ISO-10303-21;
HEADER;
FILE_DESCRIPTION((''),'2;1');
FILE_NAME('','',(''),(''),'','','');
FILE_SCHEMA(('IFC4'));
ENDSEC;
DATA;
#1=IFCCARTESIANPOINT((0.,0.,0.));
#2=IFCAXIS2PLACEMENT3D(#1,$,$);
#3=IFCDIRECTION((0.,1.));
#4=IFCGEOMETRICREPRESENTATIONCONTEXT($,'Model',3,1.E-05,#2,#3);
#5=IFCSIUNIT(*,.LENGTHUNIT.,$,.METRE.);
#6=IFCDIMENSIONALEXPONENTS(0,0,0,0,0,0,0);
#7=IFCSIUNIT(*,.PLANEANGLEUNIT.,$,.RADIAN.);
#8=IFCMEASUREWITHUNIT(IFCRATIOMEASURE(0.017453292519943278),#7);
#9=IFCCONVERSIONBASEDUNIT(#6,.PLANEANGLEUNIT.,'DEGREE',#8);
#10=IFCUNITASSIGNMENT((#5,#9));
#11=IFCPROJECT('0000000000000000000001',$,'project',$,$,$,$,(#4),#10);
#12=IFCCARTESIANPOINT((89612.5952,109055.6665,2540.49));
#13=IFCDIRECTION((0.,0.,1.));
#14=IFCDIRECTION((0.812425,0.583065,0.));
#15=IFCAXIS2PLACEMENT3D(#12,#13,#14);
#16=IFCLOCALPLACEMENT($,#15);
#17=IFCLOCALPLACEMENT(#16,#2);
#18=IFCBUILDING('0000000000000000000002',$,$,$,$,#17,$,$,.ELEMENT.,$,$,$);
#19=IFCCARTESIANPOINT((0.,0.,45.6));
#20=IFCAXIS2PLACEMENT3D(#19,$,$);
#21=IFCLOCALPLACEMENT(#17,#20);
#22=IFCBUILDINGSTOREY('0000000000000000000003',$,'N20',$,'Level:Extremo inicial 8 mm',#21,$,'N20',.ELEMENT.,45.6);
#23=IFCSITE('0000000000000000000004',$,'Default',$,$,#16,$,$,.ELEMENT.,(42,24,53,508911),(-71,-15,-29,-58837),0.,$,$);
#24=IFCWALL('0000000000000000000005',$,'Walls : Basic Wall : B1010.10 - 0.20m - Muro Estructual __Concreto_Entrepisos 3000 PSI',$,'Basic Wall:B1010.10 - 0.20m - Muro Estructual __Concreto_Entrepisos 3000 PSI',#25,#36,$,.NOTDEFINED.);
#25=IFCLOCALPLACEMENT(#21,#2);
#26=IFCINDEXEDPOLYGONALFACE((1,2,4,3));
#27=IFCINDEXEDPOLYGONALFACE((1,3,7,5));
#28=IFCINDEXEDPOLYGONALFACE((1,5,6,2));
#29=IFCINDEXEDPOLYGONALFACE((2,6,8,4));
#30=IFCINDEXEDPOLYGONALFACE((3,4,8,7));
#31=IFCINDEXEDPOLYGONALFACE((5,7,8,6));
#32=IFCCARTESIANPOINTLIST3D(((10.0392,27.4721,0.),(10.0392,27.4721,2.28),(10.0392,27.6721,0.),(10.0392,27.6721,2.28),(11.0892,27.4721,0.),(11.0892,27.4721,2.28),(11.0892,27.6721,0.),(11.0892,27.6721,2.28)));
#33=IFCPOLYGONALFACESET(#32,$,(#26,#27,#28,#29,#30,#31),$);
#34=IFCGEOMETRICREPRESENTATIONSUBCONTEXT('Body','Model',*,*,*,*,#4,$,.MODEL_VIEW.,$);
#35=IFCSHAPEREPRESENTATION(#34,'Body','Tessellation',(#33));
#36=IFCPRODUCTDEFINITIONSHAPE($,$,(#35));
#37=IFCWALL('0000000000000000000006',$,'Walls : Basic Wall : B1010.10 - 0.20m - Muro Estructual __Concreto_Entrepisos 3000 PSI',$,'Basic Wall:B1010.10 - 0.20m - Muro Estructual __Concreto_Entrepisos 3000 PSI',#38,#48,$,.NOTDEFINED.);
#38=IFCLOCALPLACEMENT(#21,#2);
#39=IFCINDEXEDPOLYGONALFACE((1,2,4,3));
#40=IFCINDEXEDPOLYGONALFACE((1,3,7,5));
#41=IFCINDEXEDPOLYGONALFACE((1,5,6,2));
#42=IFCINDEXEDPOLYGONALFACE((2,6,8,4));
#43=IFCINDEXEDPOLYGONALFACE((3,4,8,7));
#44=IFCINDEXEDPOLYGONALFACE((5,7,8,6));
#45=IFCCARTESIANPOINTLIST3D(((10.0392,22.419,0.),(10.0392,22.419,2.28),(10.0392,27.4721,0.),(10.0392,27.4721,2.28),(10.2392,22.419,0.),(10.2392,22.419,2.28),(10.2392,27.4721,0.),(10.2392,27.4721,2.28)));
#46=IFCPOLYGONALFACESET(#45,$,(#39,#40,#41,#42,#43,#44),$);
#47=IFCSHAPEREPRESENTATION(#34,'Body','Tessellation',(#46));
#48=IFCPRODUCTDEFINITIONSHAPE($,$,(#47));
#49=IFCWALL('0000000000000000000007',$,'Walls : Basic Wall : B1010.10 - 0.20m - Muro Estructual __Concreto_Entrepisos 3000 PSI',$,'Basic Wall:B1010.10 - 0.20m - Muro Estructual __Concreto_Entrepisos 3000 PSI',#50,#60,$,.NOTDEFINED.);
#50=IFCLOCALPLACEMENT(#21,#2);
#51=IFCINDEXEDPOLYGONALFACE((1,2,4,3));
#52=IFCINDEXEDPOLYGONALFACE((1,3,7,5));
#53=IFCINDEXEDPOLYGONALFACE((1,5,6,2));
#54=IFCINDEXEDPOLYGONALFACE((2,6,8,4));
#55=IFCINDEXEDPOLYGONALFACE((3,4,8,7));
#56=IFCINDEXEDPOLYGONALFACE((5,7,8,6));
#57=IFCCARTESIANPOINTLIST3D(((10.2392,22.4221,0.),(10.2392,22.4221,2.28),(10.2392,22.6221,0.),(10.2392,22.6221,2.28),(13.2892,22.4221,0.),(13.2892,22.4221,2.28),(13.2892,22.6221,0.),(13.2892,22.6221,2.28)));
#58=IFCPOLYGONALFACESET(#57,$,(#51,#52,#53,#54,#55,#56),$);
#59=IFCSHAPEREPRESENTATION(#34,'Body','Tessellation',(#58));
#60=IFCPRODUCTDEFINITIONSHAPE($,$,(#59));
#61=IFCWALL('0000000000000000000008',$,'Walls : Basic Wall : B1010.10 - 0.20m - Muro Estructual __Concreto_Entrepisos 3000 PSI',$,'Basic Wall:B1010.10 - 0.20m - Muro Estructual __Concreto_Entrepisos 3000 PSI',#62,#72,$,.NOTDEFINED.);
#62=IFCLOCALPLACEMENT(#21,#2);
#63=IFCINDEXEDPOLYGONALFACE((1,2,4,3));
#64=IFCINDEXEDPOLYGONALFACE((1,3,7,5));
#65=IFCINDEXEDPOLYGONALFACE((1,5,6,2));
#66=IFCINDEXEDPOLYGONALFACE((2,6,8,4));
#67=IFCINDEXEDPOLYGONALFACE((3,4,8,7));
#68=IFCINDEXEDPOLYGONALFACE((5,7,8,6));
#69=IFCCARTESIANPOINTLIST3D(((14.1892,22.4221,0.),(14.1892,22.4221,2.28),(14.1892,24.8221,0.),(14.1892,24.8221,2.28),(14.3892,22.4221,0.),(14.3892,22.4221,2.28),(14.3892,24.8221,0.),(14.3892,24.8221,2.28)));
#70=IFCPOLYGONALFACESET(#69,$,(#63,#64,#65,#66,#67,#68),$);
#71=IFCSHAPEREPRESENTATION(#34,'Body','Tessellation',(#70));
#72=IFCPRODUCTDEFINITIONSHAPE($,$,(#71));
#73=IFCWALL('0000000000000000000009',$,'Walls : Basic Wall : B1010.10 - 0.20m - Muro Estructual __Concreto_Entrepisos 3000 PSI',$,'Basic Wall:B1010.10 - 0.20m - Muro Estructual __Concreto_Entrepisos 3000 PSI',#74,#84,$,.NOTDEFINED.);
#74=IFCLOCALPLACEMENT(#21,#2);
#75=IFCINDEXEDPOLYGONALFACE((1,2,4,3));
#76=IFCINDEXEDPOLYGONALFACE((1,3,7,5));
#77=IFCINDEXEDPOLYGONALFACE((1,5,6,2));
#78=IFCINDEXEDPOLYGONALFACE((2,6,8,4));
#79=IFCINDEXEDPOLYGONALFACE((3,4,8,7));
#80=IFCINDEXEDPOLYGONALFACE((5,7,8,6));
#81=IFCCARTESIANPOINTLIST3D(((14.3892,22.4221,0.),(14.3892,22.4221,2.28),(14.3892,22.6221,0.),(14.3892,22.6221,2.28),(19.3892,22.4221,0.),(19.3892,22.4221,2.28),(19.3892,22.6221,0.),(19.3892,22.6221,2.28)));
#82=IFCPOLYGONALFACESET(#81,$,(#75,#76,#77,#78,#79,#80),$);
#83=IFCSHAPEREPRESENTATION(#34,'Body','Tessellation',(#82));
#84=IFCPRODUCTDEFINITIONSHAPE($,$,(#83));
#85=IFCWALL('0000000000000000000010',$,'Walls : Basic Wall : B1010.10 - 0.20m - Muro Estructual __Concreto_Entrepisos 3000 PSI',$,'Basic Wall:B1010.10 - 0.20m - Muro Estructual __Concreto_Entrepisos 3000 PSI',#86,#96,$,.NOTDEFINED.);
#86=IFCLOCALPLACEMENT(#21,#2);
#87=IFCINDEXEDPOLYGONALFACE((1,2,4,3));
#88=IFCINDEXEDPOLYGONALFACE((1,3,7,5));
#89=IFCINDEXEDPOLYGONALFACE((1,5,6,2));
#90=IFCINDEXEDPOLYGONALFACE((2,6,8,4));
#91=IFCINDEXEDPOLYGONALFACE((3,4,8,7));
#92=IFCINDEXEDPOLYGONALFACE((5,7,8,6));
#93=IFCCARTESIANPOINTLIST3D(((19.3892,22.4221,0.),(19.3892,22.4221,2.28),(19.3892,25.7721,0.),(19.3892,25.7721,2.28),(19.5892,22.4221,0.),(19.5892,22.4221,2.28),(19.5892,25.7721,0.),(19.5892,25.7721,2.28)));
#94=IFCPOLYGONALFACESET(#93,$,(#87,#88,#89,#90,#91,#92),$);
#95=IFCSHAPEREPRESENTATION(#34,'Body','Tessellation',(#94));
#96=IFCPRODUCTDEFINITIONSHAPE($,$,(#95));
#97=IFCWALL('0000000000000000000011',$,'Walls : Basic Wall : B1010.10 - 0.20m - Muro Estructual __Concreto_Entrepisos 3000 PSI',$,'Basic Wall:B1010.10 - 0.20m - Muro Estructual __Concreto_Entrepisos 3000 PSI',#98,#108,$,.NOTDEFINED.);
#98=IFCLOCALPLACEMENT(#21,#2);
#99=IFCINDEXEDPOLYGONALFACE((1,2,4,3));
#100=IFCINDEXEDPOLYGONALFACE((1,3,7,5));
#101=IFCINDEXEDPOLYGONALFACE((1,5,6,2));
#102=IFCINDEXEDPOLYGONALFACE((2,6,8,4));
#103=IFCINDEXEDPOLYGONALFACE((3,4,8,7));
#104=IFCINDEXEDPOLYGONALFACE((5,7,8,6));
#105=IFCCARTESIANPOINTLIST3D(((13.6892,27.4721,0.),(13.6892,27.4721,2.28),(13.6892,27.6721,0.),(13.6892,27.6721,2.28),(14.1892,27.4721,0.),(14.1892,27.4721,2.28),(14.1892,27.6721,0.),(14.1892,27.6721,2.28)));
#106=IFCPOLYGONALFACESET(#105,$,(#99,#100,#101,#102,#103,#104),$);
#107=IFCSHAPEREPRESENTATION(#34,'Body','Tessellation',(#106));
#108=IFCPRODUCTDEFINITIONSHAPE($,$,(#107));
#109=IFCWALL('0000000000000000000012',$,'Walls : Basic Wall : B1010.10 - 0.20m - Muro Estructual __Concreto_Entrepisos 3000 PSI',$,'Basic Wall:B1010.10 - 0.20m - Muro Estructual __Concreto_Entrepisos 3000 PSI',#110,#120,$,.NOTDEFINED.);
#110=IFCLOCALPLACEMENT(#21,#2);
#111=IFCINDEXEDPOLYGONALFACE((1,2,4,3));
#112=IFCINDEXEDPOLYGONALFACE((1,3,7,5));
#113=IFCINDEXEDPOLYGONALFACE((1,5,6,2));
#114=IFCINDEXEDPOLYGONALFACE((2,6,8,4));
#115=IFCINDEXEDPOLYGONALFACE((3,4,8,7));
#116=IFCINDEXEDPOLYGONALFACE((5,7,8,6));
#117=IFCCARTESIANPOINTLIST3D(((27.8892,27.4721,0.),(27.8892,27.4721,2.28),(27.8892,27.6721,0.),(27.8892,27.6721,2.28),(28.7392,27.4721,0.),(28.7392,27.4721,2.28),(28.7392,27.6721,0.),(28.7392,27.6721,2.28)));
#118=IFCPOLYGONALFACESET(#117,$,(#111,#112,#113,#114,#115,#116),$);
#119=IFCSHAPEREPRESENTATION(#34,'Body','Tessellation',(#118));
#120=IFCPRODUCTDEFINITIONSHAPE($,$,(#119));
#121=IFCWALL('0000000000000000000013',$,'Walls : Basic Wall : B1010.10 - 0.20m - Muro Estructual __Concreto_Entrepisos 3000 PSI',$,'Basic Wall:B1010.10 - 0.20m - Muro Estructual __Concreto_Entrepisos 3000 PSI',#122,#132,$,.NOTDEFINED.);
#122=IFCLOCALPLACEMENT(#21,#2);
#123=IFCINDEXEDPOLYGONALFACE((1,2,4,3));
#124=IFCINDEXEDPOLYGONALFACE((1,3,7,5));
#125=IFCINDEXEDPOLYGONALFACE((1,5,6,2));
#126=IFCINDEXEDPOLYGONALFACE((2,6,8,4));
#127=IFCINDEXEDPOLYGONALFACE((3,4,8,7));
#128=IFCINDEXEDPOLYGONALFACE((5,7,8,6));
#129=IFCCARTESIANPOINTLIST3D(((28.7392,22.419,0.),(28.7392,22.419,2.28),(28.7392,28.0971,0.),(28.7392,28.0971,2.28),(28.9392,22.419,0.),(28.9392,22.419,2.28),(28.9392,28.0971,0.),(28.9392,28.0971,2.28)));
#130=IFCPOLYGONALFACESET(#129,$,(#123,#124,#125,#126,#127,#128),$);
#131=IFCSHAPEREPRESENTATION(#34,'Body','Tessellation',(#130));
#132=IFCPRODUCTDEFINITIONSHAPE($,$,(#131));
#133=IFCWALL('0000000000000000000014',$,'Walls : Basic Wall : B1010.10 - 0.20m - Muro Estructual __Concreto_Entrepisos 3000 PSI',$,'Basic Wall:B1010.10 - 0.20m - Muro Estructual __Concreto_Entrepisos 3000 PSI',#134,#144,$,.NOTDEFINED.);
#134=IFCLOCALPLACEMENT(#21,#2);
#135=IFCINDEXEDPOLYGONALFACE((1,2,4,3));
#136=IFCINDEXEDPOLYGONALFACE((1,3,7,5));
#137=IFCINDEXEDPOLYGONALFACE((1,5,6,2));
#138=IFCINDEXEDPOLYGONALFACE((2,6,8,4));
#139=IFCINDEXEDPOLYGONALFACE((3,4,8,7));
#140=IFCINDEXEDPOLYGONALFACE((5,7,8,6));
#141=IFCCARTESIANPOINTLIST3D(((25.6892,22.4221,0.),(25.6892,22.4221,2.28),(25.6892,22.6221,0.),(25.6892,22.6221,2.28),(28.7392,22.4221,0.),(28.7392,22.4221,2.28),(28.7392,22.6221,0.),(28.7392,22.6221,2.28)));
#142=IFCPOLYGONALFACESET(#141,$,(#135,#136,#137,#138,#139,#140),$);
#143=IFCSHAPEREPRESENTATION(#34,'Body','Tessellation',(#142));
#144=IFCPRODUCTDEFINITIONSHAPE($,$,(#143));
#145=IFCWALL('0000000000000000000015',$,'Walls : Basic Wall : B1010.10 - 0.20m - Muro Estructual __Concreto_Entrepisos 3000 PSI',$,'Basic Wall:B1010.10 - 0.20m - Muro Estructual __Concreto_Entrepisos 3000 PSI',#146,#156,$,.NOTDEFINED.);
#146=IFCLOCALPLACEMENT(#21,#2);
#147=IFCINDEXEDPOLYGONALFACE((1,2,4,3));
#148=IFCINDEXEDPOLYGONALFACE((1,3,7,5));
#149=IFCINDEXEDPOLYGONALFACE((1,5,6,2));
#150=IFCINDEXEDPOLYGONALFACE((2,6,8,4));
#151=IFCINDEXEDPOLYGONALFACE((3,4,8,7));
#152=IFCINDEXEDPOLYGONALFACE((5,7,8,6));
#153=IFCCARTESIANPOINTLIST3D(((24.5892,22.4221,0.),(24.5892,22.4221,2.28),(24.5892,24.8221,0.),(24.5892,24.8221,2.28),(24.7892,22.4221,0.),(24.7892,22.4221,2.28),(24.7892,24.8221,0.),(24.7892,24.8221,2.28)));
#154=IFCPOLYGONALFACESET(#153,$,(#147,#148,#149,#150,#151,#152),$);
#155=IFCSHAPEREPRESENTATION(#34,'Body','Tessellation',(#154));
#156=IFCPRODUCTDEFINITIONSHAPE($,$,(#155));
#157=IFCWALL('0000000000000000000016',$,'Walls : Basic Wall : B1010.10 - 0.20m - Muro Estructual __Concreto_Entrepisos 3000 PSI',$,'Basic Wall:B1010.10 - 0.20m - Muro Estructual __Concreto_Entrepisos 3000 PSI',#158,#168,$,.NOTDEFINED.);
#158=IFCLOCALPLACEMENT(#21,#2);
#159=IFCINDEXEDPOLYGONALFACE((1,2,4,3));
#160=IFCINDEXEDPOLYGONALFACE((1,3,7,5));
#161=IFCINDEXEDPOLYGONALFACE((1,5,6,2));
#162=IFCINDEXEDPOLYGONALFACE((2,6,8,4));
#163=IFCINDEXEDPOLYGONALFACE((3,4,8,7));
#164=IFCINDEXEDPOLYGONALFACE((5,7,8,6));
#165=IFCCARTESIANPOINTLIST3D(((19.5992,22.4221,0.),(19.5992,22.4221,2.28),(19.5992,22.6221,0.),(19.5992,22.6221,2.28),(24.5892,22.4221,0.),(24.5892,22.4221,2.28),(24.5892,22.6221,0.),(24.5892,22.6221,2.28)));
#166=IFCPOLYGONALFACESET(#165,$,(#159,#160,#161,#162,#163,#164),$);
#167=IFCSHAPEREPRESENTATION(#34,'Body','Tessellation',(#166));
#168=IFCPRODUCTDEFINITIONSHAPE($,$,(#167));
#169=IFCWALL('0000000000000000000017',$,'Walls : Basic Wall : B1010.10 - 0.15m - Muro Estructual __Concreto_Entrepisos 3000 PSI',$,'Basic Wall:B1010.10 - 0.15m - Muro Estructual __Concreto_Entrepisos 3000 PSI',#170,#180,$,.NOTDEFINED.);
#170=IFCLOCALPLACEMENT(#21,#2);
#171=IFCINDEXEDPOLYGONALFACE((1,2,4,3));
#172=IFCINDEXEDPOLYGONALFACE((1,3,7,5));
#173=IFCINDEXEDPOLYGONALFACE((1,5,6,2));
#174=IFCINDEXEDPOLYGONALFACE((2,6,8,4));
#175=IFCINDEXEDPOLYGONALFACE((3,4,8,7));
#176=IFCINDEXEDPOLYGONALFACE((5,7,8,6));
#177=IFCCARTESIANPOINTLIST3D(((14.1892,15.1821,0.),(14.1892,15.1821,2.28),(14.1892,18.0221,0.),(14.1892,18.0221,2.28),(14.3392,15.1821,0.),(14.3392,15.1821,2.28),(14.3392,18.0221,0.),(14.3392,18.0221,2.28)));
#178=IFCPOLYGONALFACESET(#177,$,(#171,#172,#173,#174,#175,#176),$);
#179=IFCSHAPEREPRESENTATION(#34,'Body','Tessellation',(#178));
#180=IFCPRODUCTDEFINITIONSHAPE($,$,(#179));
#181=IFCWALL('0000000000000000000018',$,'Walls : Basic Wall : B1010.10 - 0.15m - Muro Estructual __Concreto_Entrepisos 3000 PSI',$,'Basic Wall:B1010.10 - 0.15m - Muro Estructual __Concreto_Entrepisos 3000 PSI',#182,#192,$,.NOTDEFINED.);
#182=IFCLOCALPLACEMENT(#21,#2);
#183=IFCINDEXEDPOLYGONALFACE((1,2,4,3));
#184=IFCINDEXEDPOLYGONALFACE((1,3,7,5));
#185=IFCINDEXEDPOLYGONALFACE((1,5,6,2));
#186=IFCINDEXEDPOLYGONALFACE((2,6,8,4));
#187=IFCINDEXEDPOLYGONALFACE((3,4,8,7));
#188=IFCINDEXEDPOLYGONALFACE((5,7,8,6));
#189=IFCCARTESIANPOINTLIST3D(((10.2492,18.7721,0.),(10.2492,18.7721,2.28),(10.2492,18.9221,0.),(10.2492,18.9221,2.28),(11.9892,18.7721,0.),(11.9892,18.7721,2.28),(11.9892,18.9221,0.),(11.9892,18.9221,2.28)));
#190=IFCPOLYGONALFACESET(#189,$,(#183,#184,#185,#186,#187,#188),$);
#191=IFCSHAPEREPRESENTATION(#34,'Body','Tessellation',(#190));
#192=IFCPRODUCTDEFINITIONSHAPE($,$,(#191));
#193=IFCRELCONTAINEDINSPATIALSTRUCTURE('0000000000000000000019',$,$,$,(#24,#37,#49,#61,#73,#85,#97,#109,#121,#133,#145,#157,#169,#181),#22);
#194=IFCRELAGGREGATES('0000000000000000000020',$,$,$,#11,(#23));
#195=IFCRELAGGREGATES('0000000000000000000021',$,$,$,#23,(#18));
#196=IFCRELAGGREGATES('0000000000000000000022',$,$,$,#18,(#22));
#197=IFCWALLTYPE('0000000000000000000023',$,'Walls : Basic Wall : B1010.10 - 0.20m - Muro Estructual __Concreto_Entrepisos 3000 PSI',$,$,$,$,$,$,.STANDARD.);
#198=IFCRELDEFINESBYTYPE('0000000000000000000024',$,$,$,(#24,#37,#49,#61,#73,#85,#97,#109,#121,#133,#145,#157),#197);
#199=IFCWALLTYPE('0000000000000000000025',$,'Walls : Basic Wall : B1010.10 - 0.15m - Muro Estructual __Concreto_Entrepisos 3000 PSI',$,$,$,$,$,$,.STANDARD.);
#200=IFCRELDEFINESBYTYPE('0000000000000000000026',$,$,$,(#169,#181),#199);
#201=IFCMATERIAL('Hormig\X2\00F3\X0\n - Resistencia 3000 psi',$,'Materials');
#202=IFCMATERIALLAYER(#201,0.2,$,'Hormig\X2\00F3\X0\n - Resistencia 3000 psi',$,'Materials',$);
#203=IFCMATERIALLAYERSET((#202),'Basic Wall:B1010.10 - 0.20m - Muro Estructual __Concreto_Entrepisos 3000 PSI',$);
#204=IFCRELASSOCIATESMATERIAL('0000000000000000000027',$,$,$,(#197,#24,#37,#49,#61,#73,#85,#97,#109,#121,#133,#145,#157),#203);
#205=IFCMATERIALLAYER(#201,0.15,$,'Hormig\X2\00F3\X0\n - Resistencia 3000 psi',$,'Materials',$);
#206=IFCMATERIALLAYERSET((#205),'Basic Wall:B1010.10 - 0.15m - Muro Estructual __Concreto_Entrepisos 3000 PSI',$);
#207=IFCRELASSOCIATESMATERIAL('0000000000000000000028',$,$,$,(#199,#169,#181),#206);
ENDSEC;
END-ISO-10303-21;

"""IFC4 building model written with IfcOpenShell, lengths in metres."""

from ifc_helpers import new_model, entity, si_unit, converted_unit, direction, frame, frame_2d, origin, place, context, subcontext, project, spatial, rectangle, extrude, material, layer, layer_set, layer_usage, type_object, element, save


model = new_model("IFC4")

# Units and contexts
model_context = context("Model", 3, precision=1e-05, world=origin(), true_north=direction((0.0, 1.0)))
body_context = subcontext(model_context, "Body", "Model", "MODEL_VIEW")
ifc_project = project(units=[si_unit("LENGTHUNIT", "METRE"), converted_unit("PLANEANGLEUNIT", "DEGREE", entity("IfcRatioMeasure", 0.017453292519943278), si_unit("PLANEANGLEUNIT", "RADIAN"), dimensions=[0, 0, 0, 0, 0, 0, 0])], contexts=[model_context])

# Site, building, storey
site_placement = place(None, frame((89612.5952, 109055.6665, 2540.49), z_axis=(0.0, 0.0, 1.0), x_axis=(0.812425, 0.583065, 0.0)))
site = spatial("IfcSite", under=ifc_project, at=site_placement, Name="Default", CompositionType="ELEMENT", RefLatitude=(42, 24, 53, 508911), RefLongitude=(-71, -15, -29, -58837), RefElevation=0.0)
building_placement = place(site_placement, origin())
building = spatial("IfcBuilding", under=site, at=building_placement, CompositionType="ELEMENT")
storey_placement = place(building_placement, frame((0.0, 0.0, 45.6)))
storey = spatial("IfcBuildingStorey", under=building, at=storey_placement, Name="N20", ObjectType="Level:Extremo inicial 8 mm", LongName="N20", CompositionType="ELEMENT", Elevation=45.6)

# Walls
ifc_material = material(Name="Hormigón - Resistencia 3000 psi", Category="Materials")
ifc_layer_1 = layer(ifc_material, 0.2, Name="Hormigón - Resistencia 3000 psi", Category="Materials")
ifc_layer_set_1 = layer_set([ifc_layer_1], Name="Basic Wall:B1010.10 - 0.20m - Muro Estructual __Concreto_Entrepisos 3000 PSI")
ifc_layer_usage_1 = layer_usage(ifc_layer_set_1, "AXIS2", "POSITIVE", -0.1)
wall_type_1 = type_object("IfcWallType", Name="Walls : Basic Wall : B1010.10 - 0.20m - Muro Estructual __Concreto_Entrepisos 3000 PSI", PredefinedType="STANDARD", material=ifc_layer_set_1)
wall_1_placement = place(storey_placement, frame((11.0892, 27.5721, 0.0), z_axis=(0.0, 0.0, 1.0), x_axis=(-1.0, 0.0, 0.0)))
element("IfcWall", 1, at=wall_1_placement, inside=storey, type_object=wall_type_1, material=ifc_layer_usage_1, Name="Walls : Basic Wall : B1010.10 - 0.20m - Muro Estructual __Concreto_Entrepisos 3000 PSI", ObjectType="Basic Wall:B1010.10 - 0.20m - Muro Estructual __Concreto_Entrepisos 3000 PSI", PredefinedType="NOTDEFINED", context=body_context, shape_type="SweptSolid", body=[
    extrude(rectangle(XDim=1.05, YDim=0.2, at=frame_2d((0.525, 0.0), x_axis=(-1.0, 0.0))), origin(), (0.0, 0.0, 1.0), 2.28),
])
ifc_layer_usage_2 = layer_usage(ifc_layer_set_1, "AXIS2", "POSITIVE", -0.1)
wall_2_placement = place(storey_placement, frame((10.1392, 27.4721, 0.0), z_axis=(0.0, 0.0, 1.0), x_axis=(0.0, -1.0, 0.0)))
element("IfcWall", 2, at=wall_2_placement, inside=storey, type_object=wall_type_1, material=ifc_layer_usage_2, Name="Walls : Basic Wall : B1010.10 - 0.20m - Muro Estructual __Concreto_Entrepisos 3000 PSI", ObjectType="Basic Wall:B1010.10 - 0.20m - Muro Estructual __Concreto_Entrepisos 3000 PSI", PredefinedType="NOTDEFINED", context=body_context, shape_type="SweptSolid", body=[
    extrude(rectangle(XDim=5.0531, YDim=0.2, at=frame_2d((2.5265, 0.0), x_axis=(-1.0, 0.0))), origin(), (0.0, 0.0, 1.0), 2.28),
])
ifc_layer_usage_3 = layer_usage(ifc_layer_set_1, "AXIS2", "POSITIVE", -0.1)
wall_3_placement = place(storey_placement, frame((10.2392, 22.5221, 0.0)))
element("IfcWall", 3, at=wall_3_placement, inside=storey, type_object=wall_type_1, material=ifc_layer_usage_3, Name="Walls : Basic Wall : B1010.10 - 0.20m - Muro Estructual __Concreto_Entrepisos 3000 PSI", ObjectType="Basic Wall:B1010.10 - 0.20m - Muro Estructual __Concreto_Entrepisos 3000 PSI", PredefinedType="NOTDEFINED", context=body_context, shape_type="SweptSolid", body=[
    extrude(rectangle(XDim=3.05, YDim=0.2, at=frame_2d((1.525, 0.0), x_axis=(-1.0, 0.0))), origin(), (0.0, 0.0, 1.0), 2.28),
])
ifc_layer_usage_4 = layer_usage(ifc_layer_set_1, "AXIS2", "POSITIVE", -0.1)
wall_4_placement = place(storey_placement, frame((14.2892, 24.8221, 0.0), z_axis=(0.0, 0.0, 1.0), x_axis=(0.0, -1.0, 0.0)))
element("IfcWall", 4, at=wall_4_placement, inside=storey, type_object=wall_type_1, material=ifc_layer_usage_4, Name="Walls : Basic Wall : B1010.10 - 0.20m - Muro Estructual __Concreto_Entrepisos 3000 PSI", ObjectType="Basic Wall:B1010.10 - 0.20m - Muro Estructual __Concreto_Entrepisos 3000 PSI", PredefinedType="NOTDEFINED", context=body_context, shape_type="SweptSolid", body=[
    extrude(rectangle(XDim=2.4, YDim=0.2, at=frame_2d((1.2, 0.0), x_axis=(-1.0, 0.0))), origin(), (0.0, 0.0, 1.0), 2.28),
])
ifc_layer_usage_5 = layer_usage(ifc_layer_set_1, "AXIS2", "POSITIVE", -0.1)
wall_5_placement = place(storey_placement, frame((14.3892, 22.5221, 0.0)))
element("IfcWall", 5, at=wall_5_placement, inside=storey, type_object=wall_type_1, material=ifc_layer_usage_5, Name="Walls : Basic Wall : B1010.10 - 0.20m - Muro Estructual __Concreto_Entrepisos 3000 PSI", ObjectType="Basic Wall:B1010.10 - 0.20m - Muro Estructual __Concreto_Entrepisos 3000 PSI", PredefinedType="NOTDEFINED", context=body_context, shape_type="SweptSolid", body=[
    extrude(rectangle(XDim=5.0, YDim=0.2, at=frame_2d((2.5, 0.0), x_axis=(-1.0, 0.0))), origin(), (0.0, 0.0, 1.0), 2.28),
])
ifc_layer_usage_6 = layer_usage(ifc_layer_set_1, "AXIS2", "POSITIVE", -0.1)
wall_6_placement = place(storey_placement, frame((19.4892, 22.4221, 0.0), z_axis=(0.0, 0.0, 1.0), x_axis=(0.0, 1.0, 0.0)))
element("IfcWall", 6, at=wall_6_placement, inside=storey, type_object=wall_type_1, material=ifc_layer_usage_6, Name="Walls : Basic Wall : B1010.10 - 0.20m - Muro Estructual __Concreto_Entrepisos 3000 PSI", ObjectType="Basic Wall:B1010.10 - 0.20m - Muro Estructual __Concreto_Entrepisos 3000 PSI", PredefinedType="NOTDEFINED", context=body_context, shape_type="SweptSolid", body=[
    extrude(rectangle(XDim=3.35, YDim=0.2, at=frame_2d((1.675, 0.0), x_axis=(-1.0, 0.0))), origin(), (0.0, 0.0, 1.0), 2.28),
])
ifc_layer_usage_7 = layer_usage(ifc_layer_set_1, "AXIS2", "POSITIVE", -0.1)
wall_7_placement = place(storey_placement, frame((13.6892, 27.5721, 0.0)))
element("IfcWall", 7, at=wall_7_placement, inside=storey, type_object=wall_type_1, material=ifc_layer_usage_7, Name="Walls : Basic Wall : B1010.10 - 0.20m - Muro Estructual __Concreto_Entrepisos 3000 PSI", ObjectType="Basic Wall:B1010.10 - 0.20m - Muro Estructual __Concreto_Entrepisos 3000 PSI", PredefinedType="NOTDEFINED", context=body_context, shape_type="SweptSolid", body=[
    extrude(rectangle(XDim=0.5, YDim=0.2, at=frame_2d((0.25, 0.0), x_axis=(-1.0, 0.0))), origin(), (0.0, 0.0, 1.0), 2.28),
])
ifc_layer_usage_8 = layer_usage(ifc_layer_set_1, "AXIS2", "NEGATIVE", 0.1)
wall_8_placement = place(storey_placement, frame((27.8892, 27.5721, 0.0)))
element("IfcWall", 8, at=wall_8_placement, inside=storey, type_object=wall_type_1, material=ifc_layer_usage_8, Name="Walls : Basic Wall : B1010.10 - 0.20m - Muro Estructual __Concreto_Entrepisos 3000 PSI", ObjectType="Basic Wall:B1010.10 - 0.20m - Muro Estructual __Concreto_Entrepisos 3000 PSI", PredefinedType="NOTDEFINED", context=body_context, shape_type="SweptSolid", body=[
    extrude(rectangle(XDim=0.85, YDim=0.2, at=frame_2d((0.425, 0.0), x_axis=(-1.0, 0.0))), origin(), (0.0, 0.0, 1.0), 2.28),
])
ifc_layer_usage_9 = layer_usage(ifc_layer_set_1, "AXIS2", "NEGATIVE", 0.1)
wall_9_placement = place(storey_placement, frame((28.8392, 28.0971, 0.0), z_axis=(0.0, 0.0, 1.0), x_axis=(0.0, -1.0, 0.0)))
element("IfcWall", 9, at=wall_9_placement, inside=storey, type_object=wall_type_1, material=ifc_layer_usage_9, Name="Walls : Basic Wall : B1010.10 - 0.20m - Muro Estructual __Concreto_Entrepisos 3000 PSI", ObjectType="Basic Wall:B1010.10 - 0.20m - Muro Estructual __Concreto_Entrepisos 3000 PSI", PredefinedType="NOTDEFINED", context=body_context, shape_type="SweptSolid", body=[
    extrude(rectangle(XDim=5.6781, YDim=0.2, at=frame_2d((2.839, 0.0), x_axis=(-1.0, 0.0))), origin(), (0.0, 0.0, 1.0), 2.28),
])
ifc_layer_usage_10 = layer_usage(ifc_layer_set_1, "AXIS2", "NEGATIVE", 0.1)
wall_10_placement = place(storey_placement, frame((28.7392, 22.5221, 0.0), z_axis=(0.0, 0.0, 1.0), x_axis=(-1.0, 0.0, 0.0)))
element("IfcWall", 10, at=wall_10_placement, inside=storey, type_object=wall_type_1, material=ifc_layer_usage_10, Name="Walls : Basic Wall : B1010.10 - 0.20m - Muro Estructual __Concreto_Entrepisos 3000 PSI", ObjectType="Basic Wall:B1010.10 - 0.20m - Muro Estructual __Concreto_Entrepisos 3000 PSI", PredefinedType="NOTDEFINED", context=body_context, shape_type="SweptSolid", body=[
    extrude(rectangle(XDim=3.05, YDim=0.2, at=frame_2d((1.525, 0.0), x_axis=(-1.0, 0.0))), origin(), (0.0, 0.0, 1.0), 2.28),
])
ifc_layer_usage_11 = layer_usage(ifc_layer_set_1, "AXIS2", "NEGATIVE", 0.1)
wall_11_placement = place(storey_placement, frame((24.6892, 24.8221, 0.0), z_axis=(0.0, 0.0, 1.0), x_axis=(0.0, -1.0, 0.0)))
element("IfcWall", 11, at=wall_11_placement, inside=storey, type_object=wall_type_1, material=ifc_layer_usage_11, Name="Walls : Basic Wall : B1010.10 - 0.20m - Muro Estructual __Concreto_Entrepisos 3000 PSI", ObjectType="Basic Wall:B1010.10 - 0.20m - Muro Estructual __Concreto_Entrepisos 3000 PSI", PredefinedType="NOTDEFINED", context=body_context, shape_type="SweptSolid", body=[
    extrude(rectangle(XDim=2.4, YDim=0.2, at=frame_2d((1.2, 0.0), x_axis=(-1.0, 0.0))), origin(), (0.0, 0.0, 1.0), 2.28),
])
ifc_layer_usage_12 = layer_usage(ifc_layer_set_1, "AXIS2", "NEGATIVE", 0.1)
wall_12_placement = place(storey_placement, frame((24.5892, 22.5221, 0.0), z_axis=(0.0, 0.0, 1.0), x_axis=(-1.0, 0.0, 0.0)))
element("IfcWall", 12, at=wall_12_placement, inside=storey, type_object=wall_type_1, material=ifc_layer_usage_12, Name="Walls : Basic Wall : B1010.10 - 0.20m - Muro Estructual __Concreto_Entrepisos 3000 PSI", ObjectType="Basic Wall:B1010.10 - 0.20m - Muro Estructual __Concreto_Entrepisos 3000 PSI", PredefinedType="NOTDEFINED", context=body_context, shape_type="SweptSolid", body=[
    extrude(rectangle(XDim=4.99, YDim=0.2, at=frame_2d((2.495, 0.0), x_axis=(-1.0, 0.0))), origin(), (0.0, 0.0, 1.0), 2.28),
])
ifc_layer_2 = layer(ifc_material, 0.15, Name="Hormigón - Resistencia 3000 psi", Category="Materials")
ifc_layer_set_2 = layer_set([ifc_layer_2], Name="Basic Wall:B1010.10 - 0.15m - Muro Estructual __Concreto_Entrepisos 3000 PSI")
ifc_layer_usage_13 = layer_usage(ifc_layer_set_2, "AXIS2", "NEGATIVE", 0.075)
wall_type_2 = type_object("IfcWallType", Name="Walls : Basic Wall : B1010.10 - 0.15m - Muro Estructual __Concreto_Entrepisos 3000 PSI", PredefinedType="STANDARD", material=ifc_layer_set_2)
wall_13_placement = place(storey_placement, frame((14.2642, 15.1821, 0.0), z_axis=(0.0, 0.0, 1.0), x_axis=(0.0, 1.0, 0.0)))
element("IfcWall", 13, at=wall_13_placement, inside=storey, type_object=wall_type_2, material=ifc_layer_usage_13, Name="Walls : Basic Wall : B1010.10 - 0.15m - Muro Estructual __Concreto_Entrepisos 3000 PSI", ObjectType="Basic Wall:B1010.10 - 0.15m - Muro Estructual __Concreto_Entrepisos 3000 PSI", PredefinedType="NOTDEFINED", context=body_context, shape_type="SweptSolid", body=[
    extrude(rectangle(XDim=2.84, YDim=0.15, at=frame_2d((1.42, 0.0), x_axis=(-1.0, 0.0))), origin(), (0.0, 0.0, 1.0), 2.28),
])
ifc_layer_usage_14 = layer_usage(ifc_layer_set_2, "AXIS2", "NEGATIVE", 0.075)
wall_14_placement = place(storey_placement, frame((11.9892, 18.8471, 0.0), z_axis=(0.0, 0.0, 1.0), x_axis=(-1.0, 0.0, 0.0)))
element("IfcWall", 14, at=wall_14_placement, inside=storey, type_object=wall_type_2, material=ifc_layer_usage_14, Name="Walls : Basic Wall : B1010.10 - 0.15m - Muro Estructual __Concreto_Entrepisos 3000 PSI", ObjectType="Basic Wall:B1010.10 - 0.15m - Muro Estructual __Concreto_Entrepisos 3000 PSI", PredefinedType="NOTDEFINED", context=body_context, shape_type="SweptSolid", body=[
    extrude(rectangle(XDim=1.74, YDim=0.15, at=frame_2d((0.87, 0.0), x_axis=(-1.0, 0.0))), origin(), (0.0, 0.0, 1.0), 2.28),
])

save(model, "model.ifc")
